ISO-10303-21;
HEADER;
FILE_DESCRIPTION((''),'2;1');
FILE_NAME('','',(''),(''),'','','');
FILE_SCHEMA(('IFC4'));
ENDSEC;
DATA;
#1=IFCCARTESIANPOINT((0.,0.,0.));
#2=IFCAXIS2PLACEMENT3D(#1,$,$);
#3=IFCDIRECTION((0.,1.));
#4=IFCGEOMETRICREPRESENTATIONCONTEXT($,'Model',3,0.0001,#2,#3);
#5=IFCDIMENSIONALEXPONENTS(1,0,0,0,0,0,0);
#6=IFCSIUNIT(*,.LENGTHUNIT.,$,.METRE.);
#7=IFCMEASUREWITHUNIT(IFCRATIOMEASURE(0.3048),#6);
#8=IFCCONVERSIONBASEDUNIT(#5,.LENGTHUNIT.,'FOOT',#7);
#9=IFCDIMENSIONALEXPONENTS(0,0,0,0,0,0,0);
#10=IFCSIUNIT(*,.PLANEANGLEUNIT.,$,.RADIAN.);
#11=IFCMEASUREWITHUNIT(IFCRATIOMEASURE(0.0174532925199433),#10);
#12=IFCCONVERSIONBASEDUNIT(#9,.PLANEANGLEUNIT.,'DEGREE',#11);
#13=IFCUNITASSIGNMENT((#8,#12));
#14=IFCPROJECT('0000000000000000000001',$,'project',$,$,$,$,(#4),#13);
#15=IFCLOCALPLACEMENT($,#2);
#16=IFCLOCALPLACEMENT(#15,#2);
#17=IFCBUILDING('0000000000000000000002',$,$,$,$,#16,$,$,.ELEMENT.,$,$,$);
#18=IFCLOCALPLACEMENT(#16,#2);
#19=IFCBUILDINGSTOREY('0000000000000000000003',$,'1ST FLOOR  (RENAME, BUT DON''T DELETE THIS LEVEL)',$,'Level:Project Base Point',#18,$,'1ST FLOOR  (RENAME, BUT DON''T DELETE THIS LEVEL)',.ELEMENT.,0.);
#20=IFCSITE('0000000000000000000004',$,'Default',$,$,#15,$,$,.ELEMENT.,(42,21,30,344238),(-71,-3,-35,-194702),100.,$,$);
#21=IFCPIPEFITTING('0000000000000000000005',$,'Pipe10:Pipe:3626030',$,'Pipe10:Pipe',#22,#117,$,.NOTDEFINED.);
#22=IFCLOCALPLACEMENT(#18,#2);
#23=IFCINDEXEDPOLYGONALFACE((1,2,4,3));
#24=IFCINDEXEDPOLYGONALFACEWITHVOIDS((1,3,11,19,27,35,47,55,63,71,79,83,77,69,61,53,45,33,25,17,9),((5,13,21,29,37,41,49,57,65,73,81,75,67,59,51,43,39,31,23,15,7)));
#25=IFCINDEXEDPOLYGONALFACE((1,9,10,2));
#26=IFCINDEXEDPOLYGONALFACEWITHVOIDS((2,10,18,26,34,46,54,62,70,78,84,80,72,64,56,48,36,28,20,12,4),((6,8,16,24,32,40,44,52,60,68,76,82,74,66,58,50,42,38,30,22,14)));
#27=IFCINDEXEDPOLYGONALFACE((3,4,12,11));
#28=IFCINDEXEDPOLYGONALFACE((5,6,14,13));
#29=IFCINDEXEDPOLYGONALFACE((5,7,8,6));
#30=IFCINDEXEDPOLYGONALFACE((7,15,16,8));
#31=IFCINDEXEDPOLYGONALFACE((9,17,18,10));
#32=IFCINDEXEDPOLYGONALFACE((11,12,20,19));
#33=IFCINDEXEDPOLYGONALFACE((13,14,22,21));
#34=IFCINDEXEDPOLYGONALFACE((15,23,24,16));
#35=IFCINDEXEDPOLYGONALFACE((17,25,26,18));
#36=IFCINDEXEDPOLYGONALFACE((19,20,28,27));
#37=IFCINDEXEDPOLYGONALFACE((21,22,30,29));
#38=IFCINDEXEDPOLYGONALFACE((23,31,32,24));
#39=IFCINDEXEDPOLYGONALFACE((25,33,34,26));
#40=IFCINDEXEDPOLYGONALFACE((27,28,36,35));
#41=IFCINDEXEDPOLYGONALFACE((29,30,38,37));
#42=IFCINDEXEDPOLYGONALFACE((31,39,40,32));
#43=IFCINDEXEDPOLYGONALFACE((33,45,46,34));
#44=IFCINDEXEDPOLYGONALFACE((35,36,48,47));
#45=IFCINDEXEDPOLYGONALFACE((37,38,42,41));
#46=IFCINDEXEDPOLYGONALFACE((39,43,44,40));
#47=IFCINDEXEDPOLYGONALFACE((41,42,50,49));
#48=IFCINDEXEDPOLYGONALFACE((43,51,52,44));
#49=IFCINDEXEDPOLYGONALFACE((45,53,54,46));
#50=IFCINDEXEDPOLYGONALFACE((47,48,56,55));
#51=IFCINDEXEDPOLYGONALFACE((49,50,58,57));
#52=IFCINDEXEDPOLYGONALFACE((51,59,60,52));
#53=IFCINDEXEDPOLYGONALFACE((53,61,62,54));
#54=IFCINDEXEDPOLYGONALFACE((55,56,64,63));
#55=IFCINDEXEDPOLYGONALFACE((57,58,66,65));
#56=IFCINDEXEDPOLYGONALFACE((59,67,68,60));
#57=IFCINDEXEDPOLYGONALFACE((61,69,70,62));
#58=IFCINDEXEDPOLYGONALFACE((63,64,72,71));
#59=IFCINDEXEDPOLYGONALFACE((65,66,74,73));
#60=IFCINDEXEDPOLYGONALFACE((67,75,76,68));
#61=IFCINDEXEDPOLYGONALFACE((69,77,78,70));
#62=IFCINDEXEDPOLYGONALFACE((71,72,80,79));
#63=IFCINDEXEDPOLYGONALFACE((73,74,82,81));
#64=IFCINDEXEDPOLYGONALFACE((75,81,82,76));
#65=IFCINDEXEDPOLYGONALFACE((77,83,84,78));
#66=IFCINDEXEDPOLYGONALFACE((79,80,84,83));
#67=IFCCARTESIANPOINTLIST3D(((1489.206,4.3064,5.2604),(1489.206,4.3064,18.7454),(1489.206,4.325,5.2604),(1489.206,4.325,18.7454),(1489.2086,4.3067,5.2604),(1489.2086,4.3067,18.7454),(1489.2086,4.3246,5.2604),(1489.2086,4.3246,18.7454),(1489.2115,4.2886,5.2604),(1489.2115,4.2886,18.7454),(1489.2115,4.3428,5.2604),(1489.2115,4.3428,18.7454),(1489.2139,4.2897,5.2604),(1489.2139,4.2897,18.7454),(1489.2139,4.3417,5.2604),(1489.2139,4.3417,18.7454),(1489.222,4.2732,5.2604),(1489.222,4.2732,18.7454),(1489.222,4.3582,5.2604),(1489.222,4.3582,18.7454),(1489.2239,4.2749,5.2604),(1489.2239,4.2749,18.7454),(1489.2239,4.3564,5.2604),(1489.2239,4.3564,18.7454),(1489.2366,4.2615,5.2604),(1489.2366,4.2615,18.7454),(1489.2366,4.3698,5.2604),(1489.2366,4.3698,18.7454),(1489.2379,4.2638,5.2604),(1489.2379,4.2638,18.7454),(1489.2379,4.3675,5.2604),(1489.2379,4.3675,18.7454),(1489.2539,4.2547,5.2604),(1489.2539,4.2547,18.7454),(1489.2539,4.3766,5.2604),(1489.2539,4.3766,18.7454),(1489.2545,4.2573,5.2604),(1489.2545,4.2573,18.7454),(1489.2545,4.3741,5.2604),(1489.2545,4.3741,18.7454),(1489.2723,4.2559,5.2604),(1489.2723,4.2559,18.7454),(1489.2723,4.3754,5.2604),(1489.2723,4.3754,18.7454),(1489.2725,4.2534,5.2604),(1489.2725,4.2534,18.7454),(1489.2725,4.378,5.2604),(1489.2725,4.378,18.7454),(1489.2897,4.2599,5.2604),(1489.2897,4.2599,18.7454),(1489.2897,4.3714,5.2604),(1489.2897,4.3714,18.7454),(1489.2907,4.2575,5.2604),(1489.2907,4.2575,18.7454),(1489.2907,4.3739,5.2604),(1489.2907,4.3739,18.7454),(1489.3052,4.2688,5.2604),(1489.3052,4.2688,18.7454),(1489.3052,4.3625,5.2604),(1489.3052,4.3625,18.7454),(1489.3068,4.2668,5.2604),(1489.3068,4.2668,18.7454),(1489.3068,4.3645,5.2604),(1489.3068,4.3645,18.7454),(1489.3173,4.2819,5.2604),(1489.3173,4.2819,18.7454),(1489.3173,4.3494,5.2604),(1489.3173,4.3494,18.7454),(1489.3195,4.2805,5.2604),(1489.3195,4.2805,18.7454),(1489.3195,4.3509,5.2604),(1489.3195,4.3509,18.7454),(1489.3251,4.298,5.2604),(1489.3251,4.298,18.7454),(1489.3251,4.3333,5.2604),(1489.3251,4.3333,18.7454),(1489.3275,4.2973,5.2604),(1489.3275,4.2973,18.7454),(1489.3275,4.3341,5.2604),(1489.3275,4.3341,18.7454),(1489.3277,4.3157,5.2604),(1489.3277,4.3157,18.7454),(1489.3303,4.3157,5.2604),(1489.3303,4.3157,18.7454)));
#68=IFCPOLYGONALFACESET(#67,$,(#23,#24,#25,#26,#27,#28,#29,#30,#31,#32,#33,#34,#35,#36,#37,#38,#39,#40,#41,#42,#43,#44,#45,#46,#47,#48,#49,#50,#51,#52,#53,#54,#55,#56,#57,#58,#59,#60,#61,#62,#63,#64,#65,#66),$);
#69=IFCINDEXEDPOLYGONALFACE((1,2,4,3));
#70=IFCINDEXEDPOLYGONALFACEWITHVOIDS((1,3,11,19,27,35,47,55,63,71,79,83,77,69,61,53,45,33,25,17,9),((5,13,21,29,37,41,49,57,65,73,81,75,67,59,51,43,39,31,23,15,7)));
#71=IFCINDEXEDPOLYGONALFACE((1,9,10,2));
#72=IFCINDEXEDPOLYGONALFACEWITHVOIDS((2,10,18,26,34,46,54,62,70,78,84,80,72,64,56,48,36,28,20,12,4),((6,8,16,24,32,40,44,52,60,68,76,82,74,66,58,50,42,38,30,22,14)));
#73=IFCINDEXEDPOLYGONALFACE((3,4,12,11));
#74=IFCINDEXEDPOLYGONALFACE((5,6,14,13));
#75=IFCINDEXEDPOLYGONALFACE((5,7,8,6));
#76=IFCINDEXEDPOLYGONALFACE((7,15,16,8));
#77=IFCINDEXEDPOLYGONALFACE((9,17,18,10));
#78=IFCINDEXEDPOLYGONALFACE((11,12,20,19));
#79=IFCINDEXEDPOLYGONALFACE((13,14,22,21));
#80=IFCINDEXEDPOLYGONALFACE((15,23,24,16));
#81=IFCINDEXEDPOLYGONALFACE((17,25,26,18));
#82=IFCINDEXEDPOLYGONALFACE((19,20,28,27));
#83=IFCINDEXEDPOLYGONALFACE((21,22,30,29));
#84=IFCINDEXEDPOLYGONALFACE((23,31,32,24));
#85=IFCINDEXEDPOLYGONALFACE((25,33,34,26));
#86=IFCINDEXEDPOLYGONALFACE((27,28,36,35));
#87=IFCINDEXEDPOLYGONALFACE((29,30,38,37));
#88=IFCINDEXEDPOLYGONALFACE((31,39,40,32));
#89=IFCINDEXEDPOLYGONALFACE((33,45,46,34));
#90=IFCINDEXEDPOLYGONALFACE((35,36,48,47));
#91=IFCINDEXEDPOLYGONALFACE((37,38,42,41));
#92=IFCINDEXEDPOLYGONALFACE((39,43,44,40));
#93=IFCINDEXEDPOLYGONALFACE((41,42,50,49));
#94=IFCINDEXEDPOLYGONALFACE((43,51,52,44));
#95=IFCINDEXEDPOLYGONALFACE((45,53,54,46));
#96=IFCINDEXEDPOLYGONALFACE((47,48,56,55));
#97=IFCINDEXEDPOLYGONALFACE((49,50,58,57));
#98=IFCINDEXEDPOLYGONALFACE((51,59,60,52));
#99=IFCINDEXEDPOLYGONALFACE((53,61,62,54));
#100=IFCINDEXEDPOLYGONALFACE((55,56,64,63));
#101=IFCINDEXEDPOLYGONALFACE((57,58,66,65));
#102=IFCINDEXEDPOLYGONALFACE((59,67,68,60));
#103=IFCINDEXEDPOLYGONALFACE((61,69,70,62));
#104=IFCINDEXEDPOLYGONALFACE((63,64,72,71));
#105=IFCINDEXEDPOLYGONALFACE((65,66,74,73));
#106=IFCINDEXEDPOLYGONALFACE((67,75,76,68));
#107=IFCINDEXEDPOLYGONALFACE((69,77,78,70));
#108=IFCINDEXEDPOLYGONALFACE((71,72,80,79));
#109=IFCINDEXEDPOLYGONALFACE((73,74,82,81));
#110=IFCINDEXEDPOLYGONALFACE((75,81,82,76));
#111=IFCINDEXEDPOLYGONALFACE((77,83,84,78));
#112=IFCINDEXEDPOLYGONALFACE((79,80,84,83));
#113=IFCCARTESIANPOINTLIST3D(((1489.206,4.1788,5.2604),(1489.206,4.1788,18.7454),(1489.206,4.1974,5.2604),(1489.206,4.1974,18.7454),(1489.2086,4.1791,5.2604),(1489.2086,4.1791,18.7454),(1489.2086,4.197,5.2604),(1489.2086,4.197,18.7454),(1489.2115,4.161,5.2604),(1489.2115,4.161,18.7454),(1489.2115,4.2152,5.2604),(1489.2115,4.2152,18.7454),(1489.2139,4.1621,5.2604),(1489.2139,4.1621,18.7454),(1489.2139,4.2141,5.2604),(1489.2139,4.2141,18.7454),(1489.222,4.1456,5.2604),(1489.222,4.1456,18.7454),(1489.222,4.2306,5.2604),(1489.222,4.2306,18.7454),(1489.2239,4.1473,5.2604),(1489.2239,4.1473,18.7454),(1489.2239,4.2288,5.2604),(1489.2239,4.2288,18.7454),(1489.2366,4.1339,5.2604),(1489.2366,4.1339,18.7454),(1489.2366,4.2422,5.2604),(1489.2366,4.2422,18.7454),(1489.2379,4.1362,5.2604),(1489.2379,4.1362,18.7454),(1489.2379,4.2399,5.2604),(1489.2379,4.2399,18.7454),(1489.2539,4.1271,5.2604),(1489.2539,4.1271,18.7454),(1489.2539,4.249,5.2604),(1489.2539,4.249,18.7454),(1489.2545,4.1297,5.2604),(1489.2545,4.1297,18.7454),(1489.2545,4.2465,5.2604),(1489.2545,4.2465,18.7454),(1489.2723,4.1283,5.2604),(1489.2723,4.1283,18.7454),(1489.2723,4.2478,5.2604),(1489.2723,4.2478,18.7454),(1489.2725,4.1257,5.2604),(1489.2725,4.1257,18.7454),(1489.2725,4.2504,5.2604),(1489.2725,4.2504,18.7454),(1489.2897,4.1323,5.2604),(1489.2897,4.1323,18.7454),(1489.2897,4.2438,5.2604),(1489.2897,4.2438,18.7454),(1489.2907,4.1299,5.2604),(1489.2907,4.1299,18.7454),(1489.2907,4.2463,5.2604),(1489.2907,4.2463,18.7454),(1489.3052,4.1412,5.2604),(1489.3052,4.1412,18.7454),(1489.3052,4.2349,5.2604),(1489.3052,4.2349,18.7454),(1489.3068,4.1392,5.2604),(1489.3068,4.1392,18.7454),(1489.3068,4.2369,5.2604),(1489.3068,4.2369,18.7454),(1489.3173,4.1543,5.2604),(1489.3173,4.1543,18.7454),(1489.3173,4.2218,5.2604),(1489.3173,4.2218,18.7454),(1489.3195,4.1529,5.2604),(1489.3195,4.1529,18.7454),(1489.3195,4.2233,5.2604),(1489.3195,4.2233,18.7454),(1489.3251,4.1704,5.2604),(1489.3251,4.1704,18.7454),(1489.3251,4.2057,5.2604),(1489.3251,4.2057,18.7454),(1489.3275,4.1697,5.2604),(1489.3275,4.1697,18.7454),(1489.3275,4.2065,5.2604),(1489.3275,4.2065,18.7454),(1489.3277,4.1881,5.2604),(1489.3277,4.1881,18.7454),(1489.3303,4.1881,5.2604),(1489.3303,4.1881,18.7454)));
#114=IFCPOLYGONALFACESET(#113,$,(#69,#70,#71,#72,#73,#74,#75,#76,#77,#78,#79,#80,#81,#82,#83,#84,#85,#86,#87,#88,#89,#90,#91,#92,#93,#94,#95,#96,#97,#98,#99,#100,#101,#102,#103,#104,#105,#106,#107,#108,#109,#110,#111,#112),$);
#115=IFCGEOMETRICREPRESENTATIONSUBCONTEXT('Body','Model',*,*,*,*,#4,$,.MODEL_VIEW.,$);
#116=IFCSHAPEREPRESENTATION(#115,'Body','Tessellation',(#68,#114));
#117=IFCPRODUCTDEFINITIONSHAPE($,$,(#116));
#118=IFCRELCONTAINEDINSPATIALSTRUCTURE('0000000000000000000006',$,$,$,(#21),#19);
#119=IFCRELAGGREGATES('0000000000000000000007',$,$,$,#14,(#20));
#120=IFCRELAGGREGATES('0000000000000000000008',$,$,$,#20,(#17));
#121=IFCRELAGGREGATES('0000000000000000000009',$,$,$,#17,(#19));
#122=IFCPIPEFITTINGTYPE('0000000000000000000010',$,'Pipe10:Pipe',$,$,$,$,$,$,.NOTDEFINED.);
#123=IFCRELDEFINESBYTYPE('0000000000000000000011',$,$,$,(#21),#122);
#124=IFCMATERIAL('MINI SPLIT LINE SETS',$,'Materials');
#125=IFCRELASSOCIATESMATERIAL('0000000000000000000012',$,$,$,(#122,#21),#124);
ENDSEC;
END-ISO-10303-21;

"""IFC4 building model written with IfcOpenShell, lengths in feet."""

from ifc_helpers import new_model, entity, si_unit, converted_unit, direction, frame, origin, origin_2d_with_axis, place, context, subcontext, project, spatial, hollow_circle, extrude, source, transform, mapped, material, type_object, type_shapes, element, save


model = new_model("IFC4")

# Units and contexts
model_context = context("Model", 3, precision=0.0001, world=origin(), true_north=direction((0.0, 1.0)))
body_context = subcontext(model_context, "Body", "Model", "MODEL_VIEW")
ifc_project = project(units=[converted_unit("LENGTHUNIT", "FOOT", entity("IfcRatioMeasure", 0.3048), si_unit("LENGTHUNIT", "METRE"), dimensions=[1, 0, 0, 0, 0, 0, 0]), converted_unit("PLANEANGLEUNIT", "DEGREE", entity("IfcRatioMeasure", 0.0174532925199433), si_unit("PLANEANGLEUNIT", "RADIAN"), dimensions=[0, 0, 0, 0, 0, 0, 0])], contexts=[model_context])

# Site, building, storey
site_placement = place(None, origin())
site = spatial("IfcSite", under=ifc_project, at=site_placement, Name="Default", CompositionType="ELEMENT", RefLatitude=(42, 21, 30, 344238), RefLongitude=(-71, -3, -35, -194702), RefElevation=100.0)
building_placement = place(site_placement, origin())
building = spatial("IfcBuilding", under=site, at=building_placement, CompositionType="ELEMENT")
storey_placement = place(building_placement, origin())
storey = spatial("IfcBuildingStorey", under=building, at=storey_placement, Name="1ST FLOOR  (RENAME, BUT DON'T DELETE THIS LEVEL)", ObjectType="Level:Project Base Point", LongName="1ST FLOOR  (RENAME, BUT DON'T DELETE THIS LEVEL)", CompositionType="ELEMENT", Elevation=0.0)

# Shared definitions
ifc_material_1 = material(Name="MINI SPLIT LINE SETS", Category="Materials")

# Pipe fitting
pipe_fitting_type_1 = type_object("IfcPipeFittingType", Name="Pipe10:Pipe", PredefinedType="NOTDEFINED", material=ifc_material_1)
shared_shape_1 = source(origin(), body_context, "Body", "SweptSolid", [
    extrude(hollow_circle(Radius=0.0625, WallThickness=0.0026, at=origin_2d_with_axis()), frame((0.0677, 0.1953, 0.0)), (0.0, 0.0, 1.0), 13.485),
    extrude(hollow_circle(Radius=0.0625, WallThickness=0.0026, at=origin_2d_with_axis()), frame((0.0677, 0.0677, 0.0)), (0.0, 0.0, 1.0), 13.485),
])
type_shapes(pipe_fitting_type_1, [shared_shape_1])
pipe_fitting_1_placement = place(storey_placement, frame((1489.2001, 4.1203, 5.2604)))
element("IfcPipeFitting", 1, at=pipe_fitting_1_placement, inside=storey, type_object=pipe_fitting_type_1, material=ifc_material_1, Name="Pipe10:Pipe:3626030", ObjectType="Pipe10:Pipe", PredefinedType="NOTDEFINED", context=body_context, shape_type="MappedRepresentation", body=[
    mapped(shared_shape_1, transform((0.0, 0.0, 0.0), scale=1.0)),
])

save(model, "model.ifc")
